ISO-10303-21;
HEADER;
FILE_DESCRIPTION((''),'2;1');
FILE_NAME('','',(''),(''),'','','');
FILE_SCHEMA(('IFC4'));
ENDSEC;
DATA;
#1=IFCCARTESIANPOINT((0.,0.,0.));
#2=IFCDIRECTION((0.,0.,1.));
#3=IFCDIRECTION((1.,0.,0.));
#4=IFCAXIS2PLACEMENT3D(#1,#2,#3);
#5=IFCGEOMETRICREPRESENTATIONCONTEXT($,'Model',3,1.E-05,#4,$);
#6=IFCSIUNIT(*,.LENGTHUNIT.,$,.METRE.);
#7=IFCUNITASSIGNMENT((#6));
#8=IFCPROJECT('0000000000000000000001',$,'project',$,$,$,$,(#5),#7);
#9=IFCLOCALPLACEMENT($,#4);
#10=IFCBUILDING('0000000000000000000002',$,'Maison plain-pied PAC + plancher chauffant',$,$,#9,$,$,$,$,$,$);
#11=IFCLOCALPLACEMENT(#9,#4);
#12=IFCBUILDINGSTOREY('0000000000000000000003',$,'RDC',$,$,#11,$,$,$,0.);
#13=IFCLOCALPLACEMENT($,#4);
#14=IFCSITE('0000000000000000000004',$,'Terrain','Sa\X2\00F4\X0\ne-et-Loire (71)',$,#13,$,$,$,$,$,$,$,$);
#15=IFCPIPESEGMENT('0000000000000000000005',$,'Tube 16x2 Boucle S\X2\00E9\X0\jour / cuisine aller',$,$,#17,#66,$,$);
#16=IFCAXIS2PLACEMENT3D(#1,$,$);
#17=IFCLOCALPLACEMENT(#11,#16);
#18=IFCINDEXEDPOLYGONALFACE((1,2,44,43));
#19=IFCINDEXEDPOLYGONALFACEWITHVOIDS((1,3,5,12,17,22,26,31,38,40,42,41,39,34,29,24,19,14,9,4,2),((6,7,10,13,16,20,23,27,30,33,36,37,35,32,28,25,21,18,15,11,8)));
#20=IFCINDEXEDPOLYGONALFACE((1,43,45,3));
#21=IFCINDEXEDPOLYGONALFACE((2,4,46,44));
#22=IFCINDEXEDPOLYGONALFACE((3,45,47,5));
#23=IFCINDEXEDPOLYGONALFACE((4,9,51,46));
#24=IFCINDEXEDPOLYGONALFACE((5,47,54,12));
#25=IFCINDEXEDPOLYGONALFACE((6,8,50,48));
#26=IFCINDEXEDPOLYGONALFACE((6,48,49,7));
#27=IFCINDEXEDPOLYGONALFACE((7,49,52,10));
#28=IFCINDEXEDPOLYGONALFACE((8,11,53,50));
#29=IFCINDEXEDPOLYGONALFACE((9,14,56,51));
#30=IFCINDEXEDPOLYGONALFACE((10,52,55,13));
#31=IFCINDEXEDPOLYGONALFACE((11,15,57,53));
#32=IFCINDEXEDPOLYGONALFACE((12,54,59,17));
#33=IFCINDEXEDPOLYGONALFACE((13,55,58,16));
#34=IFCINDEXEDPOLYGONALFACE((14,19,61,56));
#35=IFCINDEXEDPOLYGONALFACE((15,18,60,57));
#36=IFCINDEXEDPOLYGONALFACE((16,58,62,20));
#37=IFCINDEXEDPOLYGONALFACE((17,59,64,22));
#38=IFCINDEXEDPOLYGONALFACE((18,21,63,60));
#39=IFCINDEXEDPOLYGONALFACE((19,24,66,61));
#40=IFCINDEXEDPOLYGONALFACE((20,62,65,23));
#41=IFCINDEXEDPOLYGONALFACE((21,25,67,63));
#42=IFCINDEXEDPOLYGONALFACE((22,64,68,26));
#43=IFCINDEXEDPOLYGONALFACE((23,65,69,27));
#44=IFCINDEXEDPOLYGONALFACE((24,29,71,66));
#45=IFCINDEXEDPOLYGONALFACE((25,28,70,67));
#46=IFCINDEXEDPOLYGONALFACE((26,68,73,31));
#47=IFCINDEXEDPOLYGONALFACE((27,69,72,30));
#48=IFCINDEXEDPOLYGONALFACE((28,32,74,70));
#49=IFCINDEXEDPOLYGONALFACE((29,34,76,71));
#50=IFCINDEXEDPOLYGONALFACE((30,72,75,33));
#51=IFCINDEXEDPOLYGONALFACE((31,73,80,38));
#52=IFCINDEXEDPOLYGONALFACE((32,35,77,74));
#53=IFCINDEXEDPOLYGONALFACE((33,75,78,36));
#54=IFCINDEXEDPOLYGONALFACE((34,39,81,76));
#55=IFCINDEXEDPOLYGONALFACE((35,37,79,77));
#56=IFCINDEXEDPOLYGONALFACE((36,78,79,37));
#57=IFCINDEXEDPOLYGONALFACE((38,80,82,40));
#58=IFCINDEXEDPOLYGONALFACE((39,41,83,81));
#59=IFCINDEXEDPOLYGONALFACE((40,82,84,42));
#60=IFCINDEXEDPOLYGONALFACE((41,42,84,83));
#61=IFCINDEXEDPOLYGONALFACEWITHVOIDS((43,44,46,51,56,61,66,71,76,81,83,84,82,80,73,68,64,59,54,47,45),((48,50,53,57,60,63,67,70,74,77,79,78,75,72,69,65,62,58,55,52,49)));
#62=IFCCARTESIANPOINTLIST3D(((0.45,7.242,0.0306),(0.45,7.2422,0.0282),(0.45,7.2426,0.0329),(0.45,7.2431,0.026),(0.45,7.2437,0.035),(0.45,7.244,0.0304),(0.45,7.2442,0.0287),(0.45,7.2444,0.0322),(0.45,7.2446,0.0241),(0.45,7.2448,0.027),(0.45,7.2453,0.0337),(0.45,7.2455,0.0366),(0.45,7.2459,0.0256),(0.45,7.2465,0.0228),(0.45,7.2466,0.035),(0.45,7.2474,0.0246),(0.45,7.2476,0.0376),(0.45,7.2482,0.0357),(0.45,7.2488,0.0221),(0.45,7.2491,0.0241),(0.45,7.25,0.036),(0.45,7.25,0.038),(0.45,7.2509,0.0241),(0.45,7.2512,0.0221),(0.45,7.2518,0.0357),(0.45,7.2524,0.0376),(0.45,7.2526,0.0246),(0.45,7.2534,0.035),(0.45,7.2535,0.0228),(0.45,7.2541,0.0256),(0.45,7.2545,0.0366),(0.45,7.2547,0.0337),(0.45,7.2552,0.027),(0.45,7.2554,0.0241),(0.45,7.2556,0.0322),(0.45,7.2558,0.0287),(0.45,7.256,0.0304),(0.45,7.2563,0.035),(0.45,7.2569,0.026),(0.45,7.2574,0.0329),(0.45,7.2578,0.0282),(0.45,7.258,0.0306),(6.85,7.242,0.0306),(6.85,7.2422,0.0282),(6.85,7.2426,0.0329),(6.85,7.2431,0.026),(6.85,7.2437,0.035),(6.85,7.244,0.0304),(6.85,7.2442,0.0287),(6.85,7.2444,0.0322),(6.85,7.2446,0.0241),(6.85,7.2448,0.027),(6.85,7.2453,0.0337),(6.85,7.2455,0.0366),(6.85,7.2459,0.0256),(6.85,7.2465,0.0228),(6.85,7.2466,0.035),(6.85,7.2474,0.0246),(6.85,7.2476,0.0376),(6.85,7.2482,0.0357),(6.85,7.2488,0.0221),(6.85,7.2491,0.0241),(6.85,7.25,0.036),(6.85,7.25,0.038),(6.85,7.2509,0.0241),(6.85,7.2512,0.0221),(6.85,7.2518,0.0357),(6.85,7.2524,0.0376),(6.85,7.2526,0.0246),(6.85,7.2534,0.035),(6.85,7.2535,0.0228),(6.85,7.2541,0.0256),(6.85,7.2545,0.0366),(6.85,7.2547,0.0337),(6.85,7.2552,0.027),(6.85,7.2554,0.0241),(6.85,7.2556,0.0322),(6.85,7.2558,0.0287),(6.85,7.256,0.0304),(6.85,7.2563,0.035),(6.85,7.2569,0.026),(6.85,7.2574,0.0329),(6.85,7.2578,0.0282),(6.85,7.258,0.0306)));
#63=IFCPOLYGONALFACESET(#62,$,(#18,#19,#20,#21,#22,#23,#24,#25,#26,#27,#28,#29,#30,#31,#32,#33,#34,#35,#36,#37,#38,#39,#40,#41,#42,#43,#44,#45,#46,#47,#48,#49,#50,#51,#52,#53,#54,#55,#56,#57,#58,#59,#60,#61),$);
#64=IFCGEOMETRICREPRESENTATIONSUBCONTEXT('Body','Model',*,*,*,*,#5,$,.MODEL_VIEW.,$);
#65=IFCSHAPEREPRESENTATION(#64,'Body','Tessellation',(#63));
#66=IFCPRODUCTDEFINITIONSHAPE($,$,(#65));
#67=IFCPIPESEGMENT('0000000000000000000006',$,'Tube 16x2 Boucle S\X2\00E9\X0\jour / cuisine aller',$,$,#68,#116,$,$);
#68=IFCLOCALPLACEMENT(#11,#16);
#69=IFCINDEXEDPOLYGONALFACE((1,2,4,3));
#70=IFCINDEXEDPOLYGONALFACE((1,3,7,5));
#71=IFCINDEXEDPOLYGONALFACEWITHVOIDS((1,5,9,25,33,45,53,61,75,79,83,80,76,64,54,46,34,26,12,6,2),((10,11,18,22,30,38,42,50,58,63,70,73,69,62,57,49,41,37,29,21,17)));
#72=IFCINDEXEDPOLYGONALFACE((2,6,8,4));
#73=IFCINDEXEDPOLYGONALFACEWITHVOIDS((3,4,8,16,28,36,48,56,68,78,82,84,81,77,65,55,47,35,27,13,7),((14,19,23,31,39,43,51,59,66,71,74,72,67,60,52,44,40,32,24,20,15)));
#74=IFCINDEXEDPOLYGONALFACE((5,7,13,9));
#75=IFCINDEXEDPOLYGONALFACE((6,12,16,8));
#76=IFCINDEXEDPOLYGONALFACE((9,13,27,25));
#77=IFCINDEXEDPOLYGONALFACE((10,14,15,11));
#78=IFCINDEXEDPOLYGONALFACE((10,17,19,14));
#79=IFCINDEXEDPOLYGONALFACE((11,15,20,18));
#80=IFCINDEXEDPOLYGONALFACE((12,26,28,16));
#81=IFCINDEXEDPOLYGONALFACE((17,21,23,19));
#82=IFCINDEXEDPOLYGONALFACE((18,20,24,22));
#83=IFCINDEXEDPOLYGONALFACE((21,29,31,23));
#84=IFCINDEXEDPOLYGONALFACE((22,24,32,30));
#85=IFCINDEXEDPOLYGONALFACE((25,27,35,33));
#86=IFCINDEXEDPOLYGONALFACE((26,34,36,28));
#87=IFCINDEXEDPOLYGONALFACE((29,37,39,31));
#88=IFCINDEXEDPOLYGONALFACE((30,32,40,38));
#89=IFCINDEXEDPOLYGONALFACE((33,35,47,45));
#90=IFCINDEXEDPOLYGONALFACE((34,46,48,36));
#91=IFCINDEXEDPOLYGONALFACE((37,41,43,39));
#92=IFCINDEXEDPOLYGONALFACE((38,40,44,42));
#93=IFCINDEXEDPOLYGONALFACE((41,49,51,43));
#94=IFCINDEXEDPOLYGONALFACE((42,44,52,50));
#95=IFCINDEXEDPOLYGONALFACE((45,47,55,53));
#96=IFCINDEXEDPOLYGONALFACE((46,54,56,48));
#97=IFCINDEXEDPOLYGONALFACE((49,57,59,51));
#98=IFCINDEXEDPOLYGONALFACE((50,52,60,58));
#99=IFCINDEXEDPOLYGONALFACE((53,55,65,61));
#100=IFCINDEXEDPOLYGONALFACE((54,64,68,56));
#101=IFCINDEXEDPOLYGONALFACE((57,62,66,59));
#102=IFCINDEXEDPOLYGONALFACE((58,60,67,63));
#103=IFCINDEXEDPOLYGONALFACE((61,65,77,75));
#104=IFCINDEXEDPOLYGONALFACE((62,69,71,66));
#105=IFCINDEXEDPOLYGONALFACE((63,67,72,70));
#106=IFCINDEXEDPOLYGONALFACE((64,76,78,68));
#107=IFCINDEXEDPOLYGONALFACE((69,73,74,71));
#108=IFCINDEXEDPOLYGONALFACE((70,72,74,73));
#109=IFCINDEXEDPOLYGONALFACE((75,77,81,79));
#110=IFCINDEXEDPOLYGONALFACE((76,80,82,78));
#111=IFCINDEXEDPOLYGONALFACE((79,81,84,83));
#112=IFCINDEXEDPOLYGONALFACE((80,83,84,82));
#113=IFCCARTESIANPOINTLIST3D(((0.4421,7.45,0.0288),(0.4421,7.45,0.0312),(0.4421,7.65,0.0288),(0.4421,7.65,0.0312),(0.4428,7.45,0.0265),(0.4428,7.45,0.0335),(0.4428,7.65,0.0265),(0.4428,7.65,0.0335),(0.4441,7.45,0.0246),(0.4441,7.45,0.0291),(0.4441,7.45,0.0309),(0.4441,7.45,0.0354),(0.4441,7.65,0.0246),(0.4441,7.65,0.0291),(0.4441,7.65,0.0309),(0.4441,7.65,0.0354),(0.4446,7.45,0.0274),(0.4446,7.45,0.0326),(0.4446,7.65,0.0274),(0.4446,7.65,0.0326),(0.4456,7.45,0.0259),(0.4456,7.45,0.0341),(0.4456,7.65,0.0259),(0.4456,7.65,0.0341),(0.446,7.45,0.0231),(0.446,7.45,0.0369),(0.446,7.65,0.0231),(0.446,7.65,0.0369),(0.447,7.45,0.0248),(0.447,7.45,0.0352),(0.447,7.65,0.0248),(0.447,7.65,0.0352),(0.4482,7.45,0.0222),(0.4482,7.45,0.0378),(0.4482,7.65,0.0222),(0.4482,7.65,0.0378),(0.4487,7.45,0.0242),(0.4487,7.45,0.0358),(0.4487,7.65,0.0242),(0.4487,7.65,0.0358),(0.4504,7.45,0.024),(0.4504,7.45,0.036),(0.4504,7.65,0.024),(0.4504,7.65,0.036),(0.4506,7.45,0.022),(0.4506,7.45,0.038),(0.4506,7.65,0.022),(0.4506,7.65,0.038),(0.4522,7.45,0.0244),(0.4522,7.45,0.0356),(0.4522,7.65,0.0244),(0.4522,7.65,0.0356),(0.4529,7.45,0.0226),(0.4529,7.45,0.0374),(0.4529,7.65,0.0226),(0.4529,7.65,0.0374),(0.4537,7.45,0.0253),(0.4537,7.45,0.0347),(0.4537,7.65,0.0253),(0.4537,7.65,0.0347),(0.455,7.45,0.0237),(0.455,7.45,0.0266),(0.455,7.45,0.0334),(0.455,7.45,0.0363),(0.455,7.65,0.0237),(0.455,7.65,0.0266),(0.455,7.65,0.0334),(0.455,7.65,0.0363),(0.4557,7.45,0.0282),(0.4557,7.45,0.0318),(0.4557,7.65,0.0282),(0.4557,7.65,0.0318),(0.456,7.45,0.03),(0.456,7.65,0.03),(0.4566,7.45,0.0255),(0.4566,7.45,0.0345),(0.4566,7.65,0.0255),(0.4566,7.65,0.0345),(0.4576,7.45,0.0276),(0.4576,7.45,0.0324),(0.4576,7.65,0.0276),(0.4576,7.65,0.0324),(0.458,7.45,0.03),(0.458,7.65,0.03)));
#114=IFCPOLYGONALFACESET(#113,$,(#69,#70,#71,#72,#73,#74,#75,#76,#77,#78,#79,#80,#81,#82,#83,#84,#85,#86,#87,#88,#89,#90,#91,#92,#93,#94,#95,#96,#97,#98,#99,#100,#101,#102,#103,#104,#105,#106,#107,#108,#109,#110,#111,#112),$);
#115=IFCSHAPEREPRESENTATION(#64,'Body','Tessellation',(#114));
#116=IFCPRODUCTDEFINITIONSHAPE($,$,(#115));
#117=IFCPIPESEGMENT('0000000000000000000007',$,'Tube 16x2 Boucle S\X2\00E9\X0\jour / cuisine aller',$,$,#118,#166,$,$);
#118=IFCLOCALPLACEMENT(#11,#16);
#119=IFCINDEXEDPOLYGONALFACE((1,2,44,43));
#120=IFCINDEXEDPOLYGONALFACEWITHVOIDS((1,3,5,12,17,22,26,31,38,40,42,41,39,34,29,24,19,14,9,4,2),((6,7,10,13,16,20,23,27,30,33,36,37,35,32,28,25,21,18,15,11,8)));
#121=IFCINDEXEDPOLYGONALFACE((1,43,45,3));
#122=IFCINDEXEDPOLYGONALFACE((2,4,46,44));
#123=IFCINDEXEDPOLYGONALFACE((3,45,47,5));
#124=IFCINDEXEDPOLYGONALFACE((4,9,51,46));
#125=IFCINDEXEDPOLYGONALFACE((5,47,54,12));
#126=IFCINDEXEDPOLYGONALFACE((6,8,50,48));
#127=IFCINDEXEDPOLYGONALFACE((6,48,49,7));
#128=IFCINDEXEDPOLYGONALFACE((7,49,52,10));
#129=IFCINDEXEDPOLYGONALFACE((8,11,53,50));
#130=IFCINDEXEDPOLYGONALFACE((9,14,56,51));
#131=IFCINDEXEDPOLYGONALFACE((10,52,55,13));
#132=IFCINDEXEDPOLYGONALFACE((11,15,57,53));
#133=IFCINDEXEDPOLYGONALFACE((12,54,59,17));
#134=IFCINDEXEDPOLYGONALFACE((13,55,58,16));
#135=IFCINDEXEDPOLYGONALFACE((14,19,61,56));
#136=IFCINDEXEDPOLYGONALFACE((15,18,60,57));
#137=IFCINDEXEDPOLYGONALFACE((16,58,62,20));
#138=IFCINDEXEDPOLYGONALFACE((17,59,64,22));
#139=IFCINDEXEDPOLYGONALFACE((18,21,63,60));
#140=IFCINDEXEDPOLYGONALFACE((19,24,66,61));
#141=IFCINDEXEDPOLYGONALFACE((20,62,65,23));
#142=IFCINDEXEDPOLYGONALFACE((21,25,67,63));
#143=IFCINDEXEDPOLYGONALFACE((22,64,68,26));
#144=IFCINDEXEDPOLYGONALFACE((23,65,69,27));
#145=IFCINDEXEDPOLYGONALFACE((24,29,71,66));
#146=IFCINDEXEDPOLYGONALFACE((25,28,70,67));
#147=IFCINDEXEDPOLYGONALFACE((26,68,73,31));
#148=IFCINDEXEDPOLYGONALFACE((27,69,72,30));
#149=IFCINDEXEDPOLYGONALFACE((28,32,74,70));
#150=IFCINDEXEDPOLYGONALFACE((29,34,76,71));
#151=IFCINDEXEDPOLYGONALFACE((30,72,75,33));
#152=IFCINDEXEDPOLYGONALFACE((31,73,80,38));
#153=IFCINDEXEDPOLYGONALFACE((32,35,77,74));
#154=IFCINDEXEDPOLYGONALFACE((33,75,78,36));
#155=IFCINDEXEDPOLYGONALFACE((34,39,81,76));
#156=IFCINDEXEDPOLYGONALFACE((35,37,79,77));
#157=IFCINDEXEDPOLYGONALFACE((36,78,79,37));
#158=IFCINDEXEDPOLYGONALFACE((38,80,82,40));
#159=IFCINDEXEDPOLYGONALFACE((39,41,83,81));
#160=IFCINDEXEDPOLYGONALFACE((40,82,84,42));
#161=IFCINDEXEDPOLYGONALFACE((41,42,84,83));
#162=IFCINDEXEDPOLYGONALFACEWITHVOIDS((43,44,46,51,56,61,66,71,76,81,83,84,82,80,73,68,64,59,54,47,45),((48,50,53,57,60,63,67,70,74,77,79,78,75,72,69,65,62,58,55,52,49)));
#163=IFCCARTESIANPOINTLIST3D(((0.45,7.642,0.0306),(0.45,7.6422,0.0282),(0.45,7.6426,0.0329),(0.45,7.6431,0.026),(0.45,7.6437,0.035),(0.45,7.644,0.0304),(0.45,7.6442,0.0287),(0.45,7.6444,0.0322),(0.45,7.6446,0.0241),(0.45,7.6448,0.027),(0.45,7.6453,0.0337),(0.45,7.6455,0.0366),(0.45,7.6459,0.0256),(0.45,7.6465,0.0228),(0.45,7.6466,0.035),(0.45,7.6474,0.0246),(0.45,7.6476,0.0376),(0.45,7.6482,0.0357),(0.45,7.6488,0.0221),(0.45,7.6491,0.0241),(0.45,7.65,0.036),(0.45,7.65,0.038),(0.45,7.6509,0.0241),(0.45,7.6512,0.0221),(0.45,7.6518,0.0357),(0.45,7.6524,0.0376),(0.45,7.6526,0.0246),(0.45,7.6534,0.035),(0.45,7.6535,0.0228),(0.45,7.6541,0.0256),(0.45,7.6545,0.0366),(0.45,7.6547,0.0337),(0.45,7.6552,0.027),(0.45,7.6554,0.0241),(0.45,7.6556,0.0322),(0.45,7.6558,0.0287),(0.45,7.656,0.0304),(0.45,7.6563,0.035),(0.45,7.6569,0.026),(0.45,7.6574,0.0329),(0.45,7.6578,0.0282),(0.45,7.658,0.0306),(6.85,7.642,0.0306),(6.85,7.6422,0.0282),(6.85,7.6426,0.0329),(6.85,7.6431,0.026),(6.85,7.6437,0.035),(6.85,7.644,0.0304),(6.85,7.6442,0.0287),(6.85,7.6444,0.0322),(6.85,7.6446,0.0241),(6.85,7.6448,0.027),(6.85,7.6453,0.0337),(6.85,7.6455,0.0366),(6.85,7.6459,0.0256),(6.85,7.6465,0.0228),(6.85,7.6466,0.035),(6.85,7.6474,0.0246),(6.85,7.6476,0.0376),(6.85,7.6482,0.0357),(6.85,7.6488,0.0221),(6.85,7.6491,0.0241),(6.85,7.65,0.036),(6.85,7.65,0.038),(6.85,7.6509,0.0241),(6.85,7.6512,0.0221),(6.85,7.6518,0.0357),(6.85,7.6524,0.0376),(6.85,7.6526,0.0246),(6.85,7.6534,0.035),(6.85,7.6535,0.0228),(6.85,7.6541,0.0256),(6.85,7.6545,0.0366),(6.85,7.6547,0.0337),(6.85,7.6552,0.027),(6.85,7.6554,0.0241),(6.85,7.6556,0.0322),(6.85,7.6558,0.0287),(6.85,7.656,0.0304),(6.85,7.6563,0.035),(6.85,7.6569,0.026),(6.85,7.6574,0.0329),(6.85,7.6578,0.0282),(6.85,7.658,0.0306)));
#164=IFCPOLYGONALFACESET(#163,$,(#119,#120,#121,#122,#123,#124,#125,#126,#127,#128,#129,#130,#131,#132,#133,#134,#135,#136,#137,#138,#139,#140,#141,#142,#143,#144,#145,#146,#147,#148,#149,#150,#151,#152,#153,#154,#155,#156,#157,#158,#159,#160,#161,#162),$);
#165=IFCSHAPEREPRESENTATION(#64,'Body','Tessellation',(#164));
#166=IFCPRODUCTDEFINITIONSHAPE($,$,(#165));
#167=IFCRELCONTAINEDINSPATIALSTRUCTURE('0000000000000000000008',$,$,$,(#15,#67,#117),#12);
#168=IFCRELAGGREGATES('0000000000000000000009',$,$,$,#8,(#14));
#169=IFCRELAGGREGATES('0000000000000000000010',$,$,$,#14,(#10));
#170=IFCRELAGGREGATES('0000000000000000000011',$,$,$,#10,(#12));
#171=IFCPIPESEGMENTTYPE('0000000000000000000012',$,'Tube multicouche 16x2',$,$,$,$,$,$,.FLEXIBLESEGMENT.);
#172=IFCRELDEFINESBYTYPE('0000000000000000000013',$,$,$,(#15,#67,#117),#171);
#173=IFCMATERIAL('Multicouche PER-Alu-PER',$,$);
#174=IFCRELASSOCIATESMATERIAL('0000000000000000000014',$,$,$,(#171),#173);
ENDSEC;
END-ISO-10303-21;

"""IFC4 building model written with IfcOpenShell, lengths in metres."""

from ifc_helpers import new_model, si_unit, frame, origin_with_axes, place, context, subcontext, project, spatial, hollow_circle, extrude, material, type_object, element, save


model = new_model("IFC4")

# Units and contexts
model_context = context("Model", 3, precision=1e-05, world=origin_with_axes())
body_context = subcontext(model_context, "Body", "Model", "MODEL_VIEW")
ifc_project = project(units=[si_unit("LENGTHUNIT", "METRE")], contexts=[model_context])

# Site, building, storey
site_placement = place(None, origin_with_axes())
site = spatial("IfcSite", under=ifc_project, at=site_placement, Name="Terrain", Description="Saône-et-Loire (71)")
building_placement = place(None, origin_with_axes())
building = spatial("IfcBuilding", under=site, at=building_placement, Name="Maison plain-pied PAC + plancher chauffant")
storey_placement = place(building_placement, origin_with_axes())
storey = spatial("IfcBuildingStorey", under=building, at=storey_placement, Name="RDC", Elevation=0.0)

# Pipe segments
ifc_material_1 = material(Name="Multicouche PER-Alu-PER")
pipe_segment_type_1 = type_object("IfcPipeSegmentType", Name="Tube multicouche 16x2", PredefinedType="FLEXIBLESEGMENT", material=ifc_material_1)
pipe_segment_1_placement = place(storey_placement, frame((0.45, 7.25, 0.03), z_axis=(1.0, 0.0, 0.0), x_axis=(0.0, 0.0, 1.0)))
element("IfcPipeSegment", 1, at=pipe_segment_1_placement, inside=storey, type_object=pipe_segment_type_1, Name="Tube 16x2 Boucle Séjour / cuisine aller", context=body_context, shape_type="SweptSolid", body=[
    extrude(hollow_circle(Radius=0.008, WallThickness=0.002), origin_with_axes(), (0.0, 0.0, 1.0), 6.4),
])
pipe_segment_2_placement = place(storey_placement, frame((0.45, 7.45, 0.03), z_axis=(0.0, 1.0, 0.0), x_axis=(1.0, 0.0, 0.0)))
element("IfcPipeSegment", 2, at=pipe_segment_2_placement, inside=storey, type_object=pipe_segment_type_1, Name="Tube 16x2 Boucle Séjour / cuisine aller", context=body_context, shape_type="SweptSolid", body=[
    extrude(hollow_circle(Radius=0.008, WallThickness=0.002), origin_with_axes(), (0.0, 0.0, 1.0), 0.2),
])
pipe_segment_3_placement = place(storey_placement, frame((0.45, 7.65, 0.03), z_axis=(1.0, 0.0, 0.0), x_axis=(0.0, 0.0, 1.0)))
element("IfcPipeSegment", 3, at=pipe_segment_3_placement, inside=storey, type_object=pipe_segment_type_1, Name="Tube 16x2 Boucle Séjour / cuisine aller", context=body_context, shape_type="SweptSolid", body=[
    extrude(hollow_circle(Radius=0.008, WallThickness=0.002), origin_with_axes(), (0.0, 0.0, 1.0), 6.4),
])

save(model, "model.ifc")
